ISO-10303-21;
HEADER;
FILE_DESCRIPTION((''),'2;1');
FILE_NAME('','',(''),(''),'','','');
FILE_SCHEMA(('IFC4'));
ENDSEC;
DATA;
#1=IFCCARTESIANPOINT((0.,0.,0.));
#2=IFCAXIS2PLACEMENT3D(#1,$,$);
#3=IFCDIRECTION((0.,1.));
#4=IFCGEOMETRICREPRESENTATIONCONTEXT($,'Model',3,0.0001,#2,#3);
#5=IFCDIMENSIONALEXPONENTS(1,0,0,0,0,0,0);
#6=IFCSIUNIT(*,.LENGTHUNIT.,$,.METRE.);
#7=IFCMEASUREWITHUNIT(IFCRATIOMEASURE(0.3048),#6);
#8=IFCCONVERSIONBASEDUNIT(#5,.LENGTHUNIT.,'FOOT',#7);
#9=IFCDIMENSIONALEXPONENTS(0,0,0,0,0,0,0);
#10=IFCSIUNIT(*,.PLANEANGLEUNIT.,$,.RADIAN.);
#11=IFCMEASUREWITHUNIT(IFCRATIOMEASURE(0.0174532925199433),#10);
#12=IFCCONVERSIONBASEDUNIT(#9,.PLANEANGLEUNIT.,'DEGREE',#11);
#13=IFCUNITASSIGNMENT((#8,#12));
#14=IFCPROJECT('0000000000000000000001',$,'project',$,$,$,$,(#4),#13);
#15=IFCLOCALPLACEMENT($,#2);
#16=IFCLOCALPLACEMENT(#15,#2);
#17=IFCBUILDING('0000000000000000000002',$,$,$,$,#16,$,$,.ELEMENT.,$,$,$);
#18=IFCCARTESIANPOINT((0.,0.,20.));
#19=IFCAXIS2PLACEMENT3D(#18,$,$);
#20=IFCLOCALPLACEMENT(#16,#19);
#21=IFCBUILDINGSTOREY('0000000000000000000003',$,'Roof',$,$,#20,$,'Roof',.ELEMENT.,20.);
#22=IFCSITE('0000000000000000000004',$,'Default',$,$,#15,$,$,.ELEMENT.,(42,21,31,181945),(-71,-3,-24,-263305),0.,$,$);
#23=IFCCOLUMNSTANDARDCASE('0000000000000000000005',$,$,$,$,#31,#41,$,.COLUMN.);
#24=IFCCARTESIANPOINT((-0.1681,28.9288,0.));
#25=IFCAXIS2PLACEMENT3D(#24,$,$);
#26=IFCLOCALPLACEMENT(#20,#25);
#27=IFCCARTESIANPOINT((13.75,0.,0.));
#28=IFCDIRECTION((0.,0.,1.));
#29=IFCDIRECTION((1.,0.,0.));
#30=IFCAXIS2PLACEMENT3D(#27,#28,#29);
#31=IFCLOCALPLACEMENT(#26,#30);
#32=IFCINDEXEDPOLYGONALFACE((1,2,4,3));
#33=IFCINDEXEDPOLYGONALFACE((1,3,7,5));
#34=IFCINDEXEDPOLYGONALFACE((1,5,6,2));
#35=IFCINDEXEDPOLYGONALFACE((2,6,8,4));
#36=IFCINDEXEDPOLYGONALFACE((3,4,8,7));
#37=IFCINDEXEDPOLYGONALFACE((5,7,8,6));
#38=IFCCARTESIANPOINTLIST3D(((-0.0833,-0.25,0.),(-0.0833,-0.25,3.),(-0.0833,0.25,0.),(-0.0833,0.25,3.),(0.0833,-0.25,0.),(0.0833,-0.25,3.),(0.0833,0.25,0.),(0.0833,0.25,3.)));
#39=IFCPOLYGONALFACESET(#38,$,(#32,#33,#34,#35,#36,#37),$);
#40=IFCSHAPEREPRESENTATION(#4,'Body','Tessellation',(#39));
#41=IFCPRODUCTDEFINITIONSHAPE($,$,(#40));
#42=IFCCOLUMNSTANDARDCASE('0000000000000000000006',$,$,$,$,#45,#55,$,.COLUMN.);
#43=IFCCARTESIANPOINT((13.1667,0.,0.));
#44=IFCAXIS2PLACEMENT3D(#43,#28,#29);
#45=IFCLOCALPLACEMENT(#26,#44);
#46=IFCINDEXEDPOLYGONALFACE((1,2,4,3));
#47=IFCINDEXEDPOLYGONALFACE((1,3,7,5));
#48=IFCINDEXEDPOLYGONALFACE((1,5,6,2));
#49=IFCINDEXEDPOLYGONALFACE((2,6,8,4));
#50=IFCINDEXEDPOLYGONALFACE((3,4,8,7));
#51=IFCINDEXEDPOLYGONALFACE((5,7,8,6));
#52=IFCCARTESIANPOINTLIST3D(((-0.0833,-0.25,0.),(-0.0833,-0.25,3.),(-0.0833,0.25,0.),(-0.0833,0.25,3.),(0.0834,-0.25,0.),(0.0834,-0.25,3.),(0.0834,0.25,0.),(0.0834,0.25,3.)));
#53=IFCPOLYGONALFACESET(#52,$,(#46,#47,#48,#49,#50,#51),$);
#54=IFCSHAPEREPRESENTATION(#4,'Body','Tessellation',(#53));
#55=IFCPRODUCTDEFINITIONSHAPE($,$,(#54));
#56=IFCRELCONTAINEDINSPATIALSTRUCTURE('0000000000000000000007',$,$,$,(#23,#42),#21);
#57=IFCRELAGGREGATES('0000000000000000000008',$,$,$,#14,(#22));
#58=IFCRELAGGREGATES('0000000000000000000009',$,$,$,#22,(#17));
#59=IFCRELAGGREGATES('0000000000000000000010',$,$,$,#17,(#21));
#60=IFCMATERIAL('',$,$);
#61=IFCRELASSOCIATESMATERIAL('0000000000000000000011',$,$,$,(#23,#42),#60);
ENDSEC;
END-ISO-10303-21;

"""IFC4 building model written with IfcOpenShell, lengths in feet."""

from ifc_helpers import new_model, entity, si_unit, converted_unit, direction, frame, origin, place, context, project, spatial, rectangle, extrude, material, element, save


model = new_model("IFC4")

# Units and contexts
model_context = context("Model", 3, precision=0.0001, world=origin(), true_north=direction((0.0, 1.0)))
ifc_project = project(units=[converted_unit("LENGTHUNIT", "FOOT", entity("IfcRatioMeasure", 0.3048), si_unit("LENGTHUNIT", "METRE"), dimensions=[1, 0, 0, 0, 0, 0, 0]), converted_unit("PLANEANGLEUNIT", "DEGREE", entity("IfcRatioMeasure", 0.0174532925199433), si_unit("PLANEANGLEUNIT", "RADIAN"), dimensions=[0, 0, 0, 0, 0, 0, 0])], contexts=[model_context])

# Site, building, storey
site_placement = place(None, origin())
site = spatial("IfcSite", under=ifc_project, at=site_placement, Name="Default", CompositionType="ELEMENT", RefLatitude=(42, 21, 31, 181945), RefLongitude=(-71, -3, -24, -263305), RefElevation=0.0)
building_placement = place(site_placement, origin())
building = spatial("IfcBuilding", under=site, at=building_placement, CompositionType="ELEMENT")
storey_placement = place(building_placement, frame((0.0, 0.0, 20.0)))
storey = spatial("IfcBuildingStorey", under=building, at=storey_placement, Name="Roof", LongName="Roof", CompositionType="ELEMENT", Elevation=20.0)

# Columns
ifc_material_1 = material(Name="")
placement = place(storey_placement, frame((-0.1681, 28.9288, 0.0)))
for number, where, z_axis, x_axis in (
    (1, (13.75, 0.0, 0.0), (0.0, 0.0, 1.0), (1.0, 0.0, 0.0)),
    (2, (13.1667, 0.0, 0.0), (0.0, 0.0, 1.0), (1.0, 0.0, 0.0)),
):
    element("IfcColumnStandardCase", number, at=place(placement, frame(where, z_axis=z_axis, x_axis=x_axis)), inside=storey, material=ifc_material_1, PredefinedType="COLUMN", context=model_context, shape_type="SweptSolid", body=[
        extrude(rectangle(XDim=0.1667, YDim=0.5), origin(), (0.0, 0.0, 1.0), 3.0),
    ])

save(model, "model.ifc")
